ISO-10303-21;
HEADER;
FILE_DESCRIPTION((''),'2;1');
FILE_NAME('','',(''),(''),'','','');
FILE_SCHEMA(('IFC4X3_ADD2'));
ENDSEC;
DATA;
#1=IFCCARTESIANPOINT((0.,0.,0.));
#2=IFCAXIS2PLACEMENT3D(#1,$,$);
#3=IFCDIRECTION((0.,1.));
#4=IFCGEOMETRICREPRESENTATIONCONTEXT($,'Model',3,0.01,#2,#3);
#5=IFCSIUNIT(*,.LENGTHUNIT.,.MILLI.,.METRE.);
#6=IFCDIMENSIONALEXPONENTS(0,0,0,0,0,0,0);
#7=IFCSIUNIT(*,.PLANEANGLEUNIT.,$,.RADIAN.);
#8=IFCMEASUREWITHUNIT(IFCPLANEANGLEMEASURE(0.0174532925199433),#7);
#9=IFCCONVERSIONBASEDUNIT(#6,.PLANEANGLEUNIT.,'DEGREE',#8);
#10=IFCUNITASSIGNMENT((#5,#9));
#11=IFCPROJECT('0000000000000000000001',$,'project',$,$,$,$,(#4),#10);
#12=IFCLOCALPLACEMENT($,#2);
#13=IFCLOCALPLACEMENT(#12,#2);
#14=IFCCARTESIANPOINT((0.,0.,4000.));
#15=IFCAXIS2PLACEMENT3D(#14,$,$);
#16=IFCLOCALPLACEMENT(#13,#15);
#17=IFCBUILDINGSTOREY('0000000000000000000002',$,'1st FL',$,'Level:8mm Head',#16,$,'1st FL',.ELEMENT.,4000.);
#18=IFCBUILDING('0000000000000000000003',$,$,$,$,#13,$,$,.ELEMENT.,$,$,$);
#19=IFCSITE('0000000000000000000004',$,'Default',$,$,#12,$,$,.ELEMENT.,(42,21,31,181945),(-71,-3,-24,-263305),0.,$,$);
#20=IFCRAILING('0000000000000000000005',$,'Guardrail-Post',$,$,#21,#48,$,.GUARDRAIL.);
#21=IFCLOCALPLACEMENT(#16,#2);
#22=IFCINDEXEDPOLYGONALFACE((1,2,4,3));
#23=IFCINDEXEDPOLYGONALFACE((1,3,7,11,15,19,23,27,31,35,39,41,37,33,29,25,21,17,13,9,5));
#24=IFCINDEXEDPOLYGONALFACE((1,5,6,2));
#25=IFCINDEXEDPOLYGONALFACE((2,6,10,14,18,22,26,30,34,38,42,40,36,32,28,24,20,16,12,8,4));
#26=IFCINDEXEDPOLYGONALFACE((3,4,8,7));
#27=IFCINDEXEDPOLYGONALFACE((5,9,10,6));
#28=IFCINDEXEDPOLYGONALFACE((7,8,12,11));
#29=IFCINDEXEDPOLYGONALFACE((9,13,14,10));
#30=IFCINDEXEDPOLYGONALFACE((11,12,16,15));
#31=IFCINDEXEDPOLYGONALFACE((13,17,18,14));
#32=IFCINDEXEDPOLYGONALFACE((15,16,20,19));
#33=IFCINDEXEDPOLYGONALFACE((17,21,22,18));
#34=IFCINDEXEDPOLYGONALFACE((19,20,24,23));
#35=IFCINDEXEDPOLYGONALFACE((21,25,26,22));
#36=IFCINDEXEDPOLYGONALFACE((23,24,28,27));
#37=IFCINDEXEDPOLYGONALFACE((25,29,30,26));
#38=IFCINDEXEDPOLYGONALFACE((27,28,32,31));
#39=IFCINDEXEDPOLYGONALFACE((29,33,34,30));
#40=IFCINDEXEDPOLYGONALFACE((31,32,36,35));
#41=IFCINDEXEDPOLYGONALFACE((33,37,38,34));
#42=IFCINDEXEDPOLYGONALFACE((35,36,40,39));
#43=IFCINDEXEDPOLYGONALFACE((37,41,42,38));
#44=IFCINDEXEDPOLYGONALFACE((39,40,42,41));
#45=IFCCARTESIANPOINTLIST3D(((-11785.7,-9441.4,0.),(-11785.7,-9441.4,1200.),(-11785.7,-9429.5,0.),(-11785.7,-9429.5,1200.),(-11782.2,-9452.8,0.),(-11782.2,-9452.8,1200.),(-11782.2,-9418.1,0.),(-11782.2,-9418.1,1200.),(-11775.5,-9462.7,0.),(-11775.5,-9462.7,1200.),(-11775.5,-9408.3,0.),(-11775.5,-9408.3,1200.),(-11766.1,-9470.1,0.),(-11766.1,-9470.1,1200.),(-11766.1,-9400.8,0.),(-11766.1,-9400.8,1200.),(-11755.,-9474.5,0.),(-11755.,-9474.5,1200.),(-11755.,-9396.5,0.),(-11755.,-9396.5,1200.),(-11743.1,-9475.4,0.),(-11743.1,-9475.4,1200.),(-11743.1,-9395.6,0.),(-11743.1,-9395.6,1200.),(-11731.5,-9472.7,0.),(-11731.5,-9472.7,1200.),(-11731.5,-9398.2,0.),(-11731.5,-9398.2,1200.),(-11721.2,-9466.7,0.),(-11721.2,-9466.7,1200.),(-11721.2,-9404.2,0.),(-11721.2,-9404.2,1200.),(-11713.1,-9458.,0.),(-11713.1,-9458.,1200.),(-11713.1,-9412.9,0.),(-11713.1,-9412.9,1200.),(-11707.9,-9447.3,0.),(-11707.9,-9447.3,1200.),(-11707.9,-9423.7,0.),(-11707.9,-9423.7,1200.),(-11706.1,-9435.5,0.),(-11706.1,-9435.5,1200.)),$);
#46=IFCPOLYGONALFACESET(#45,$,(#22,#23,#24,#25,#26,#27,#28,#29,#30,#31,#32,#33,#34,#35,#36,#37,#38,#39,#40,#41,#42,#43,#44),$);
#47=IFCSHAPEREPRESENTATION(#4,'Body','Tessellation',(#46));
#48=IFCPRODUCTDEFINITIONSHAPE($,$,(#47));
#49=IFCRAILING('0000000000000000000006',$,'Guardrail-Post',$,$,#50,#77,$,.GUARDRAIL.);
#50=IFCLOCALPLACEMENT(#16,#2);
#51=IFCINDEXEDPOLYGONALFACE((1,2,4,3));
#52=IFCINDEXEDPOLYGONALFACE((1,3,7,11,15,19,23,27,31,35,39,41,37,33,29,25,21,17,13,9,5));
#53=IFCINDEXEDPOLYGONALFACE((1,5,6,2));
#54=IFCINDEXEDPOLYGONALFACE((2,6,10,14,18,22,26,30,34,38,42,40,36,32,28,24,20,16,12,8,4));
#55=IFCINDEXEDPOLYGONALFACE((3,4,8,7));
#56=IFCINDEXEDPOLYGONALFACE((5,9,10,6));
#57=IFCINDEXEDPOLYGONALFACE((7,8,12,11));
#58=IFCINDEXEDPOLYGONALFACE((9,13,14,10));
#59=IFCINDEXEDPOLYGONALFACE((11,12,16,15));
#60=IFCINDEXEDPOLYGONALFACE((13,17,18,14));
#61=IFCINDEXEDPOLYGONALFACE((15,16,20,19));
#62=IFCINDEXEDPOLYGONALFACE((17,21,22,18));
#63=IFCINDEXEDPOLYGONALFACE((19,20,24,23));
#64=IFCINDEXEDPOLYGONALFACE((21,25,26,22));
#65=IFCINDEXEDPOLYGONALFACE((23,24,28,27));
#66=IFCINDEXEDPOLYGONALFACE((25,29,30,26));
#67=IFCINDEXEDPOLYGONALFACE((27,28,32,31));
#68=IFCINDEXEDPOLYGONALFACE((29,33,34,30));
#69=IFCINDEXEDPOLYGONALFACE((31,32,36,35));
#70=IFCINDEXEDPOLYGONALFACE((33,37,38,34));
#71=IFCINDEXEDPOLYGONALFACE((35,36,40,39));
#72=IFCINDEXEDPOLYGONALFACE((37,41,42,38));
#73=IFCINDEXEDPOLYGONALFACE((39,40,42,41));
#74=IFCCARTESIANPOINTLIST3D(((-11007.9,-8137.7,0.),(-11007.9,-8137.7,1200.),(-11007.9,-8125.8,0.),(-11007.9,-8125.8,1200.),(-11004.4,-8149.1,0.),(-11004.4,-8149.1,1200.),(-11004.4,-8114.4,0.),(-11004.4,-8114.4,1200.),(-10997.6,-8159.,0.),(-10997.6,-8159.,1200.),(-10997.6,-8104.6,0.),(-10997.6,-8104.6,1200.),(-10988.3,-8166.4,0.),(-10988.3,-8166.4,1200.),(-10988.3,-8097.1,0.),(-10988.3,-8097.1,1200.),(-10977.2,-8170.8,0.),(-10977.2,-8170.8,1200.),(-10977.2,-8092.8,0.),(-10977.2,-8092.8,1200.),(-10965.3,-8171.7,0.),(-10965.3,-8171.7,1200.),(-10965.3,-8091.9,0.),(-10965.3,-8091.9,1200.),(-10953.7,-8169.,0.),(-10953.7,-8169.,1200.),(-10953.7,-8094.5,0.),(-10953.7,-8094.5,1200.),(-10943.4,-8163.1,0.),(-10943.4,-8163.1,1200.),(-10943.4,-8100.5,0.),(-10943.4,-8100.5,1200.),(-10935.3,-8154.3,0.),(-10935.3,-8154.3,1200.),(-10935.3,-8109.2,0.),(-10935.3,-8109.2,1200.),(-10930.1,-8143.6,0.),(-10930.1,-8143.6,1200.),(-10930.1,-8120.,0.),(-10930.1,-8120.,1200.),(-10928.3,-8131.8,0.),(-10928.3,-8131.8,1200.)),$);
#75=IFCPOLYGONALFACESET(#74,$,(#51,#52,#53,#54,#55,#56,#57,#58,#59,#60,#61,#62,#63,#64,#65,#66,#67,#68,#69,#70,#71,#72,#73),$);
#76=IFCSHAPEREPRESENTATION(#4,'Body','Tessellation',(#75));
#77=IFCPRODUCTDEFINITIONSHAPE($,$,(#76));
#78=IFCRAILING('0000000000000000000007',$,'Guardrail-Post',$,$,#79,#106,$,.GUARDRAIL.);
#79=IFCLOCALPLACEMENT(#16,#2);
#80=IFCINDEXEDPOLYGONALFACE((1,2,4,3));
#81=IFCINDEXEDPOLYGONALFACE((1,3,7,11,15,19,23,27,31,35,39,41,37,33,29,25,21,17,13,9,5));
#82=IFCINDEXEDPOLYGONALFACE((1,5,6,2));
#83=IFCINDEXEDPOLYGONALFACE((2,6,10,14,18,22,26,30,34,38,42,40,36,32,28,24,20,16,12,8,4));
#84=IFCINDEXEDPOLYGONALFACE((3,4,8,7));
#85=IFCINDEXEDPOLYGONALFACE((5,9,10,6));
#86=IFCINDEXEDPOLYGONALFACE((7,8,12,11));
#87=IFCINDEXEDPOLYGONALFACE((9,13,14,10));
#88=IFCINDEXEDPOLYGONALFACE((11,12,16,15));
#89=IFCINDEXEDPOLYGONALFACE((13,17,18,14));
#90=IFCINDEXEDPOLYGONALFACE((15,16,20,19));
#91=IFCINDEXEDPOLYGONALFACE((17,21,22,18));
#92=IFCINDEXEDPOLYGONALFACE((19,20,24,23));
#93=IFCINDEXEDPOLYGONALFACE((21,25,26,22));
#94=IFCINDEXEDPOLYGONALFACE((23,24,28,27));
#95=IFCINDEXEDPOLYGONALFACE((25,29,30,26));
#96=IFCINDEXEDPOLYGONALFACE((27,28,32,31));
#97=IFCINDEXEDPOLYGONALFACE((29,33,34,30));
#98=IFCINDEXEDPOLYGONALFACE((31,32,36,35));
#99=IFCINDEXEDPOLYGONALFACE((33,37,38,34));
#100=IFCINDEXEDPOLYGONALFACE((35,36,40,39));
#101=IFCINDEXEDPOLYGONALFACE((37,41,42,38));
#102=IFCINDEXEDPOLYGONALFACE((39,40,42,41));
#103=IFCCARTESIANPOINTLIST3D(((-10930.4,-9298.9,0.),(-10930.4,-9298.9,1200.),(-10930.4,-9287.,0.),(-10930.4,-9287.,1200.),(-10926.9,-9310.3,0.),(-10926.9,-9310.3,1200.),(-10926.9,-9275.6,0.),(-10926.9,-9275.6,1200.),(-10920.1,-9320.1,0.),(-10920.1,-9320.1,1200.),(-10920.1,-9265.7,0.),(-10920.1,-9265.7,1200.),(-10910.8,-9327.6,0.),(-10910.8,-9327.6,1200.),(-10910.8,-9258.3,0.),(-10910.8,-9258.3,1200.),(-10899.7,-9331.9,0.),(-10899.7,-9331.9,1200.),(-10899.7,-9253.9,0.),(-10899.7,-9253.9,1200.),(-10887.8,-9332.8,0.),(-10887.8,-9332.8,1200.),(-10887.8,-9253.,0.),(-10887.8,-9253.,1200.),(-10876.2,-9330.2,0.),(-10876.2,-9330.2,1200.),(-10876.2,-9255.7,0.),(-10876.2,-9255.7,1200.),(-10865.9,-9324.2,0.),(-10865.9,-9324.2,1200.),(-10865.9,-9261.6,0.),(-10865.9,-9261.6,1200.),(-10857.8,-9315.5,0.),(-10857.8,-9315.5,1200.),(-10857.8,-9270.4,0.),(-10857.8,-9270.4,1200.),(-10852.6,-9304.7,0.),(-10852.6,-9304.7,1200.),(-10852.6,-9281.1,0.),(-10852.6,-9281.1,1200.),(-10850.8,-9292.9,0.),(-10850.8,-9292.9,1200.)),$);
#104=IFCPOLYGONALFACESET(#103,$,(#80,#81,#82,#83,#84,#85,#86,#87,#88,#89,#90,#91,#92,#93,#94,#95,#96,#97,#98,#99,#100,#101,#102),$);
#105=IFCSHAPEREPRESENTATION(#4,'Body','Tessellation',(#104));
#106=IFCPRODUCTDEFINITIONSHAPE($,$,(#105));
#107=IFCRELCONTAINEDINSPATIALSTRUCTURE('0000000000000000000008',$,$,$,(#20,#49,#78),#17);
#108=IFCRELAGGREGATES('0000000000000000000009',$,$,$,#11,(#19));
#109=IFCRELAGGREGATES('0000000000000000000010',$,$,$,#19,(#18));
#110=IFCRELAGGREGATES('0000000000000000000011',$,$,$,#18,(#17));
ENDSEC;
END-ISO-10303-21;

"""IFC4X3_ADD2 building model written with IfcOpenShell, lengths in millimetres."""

from ifc_helpers import new_model, entity, si_unit, converted_unit, direction, frame, origin, origin_with_axes, origin_2d, place, context, project, spatial, circle, extrude, element, save


model = new_model("IFC4X3_ADD2")

# Units and contexts
model_context = context("Model", 3, precision=0.01, world=origin(), true_north=direction((0.0, 1.0)))
ifc_project = project(units=[si_unit("LENGTHUNIT", "METRE", prefix="MILLI"), converted_unit("PLANEANGLEUNIT", "DEGREE", entity("IfcPlaneAngleMeasure", 0.0174532925199433), si_unit("PLANEANGLEUNIT", "RADIAN"), dimensions=[0, 0, 0, 0, 0, 0, 0])], contexts=[model_context])

# Site, building, storey
site_placement = place(None, origin())
site = spatial("IfcSite", under=ifc_project, at=site_placement, Name="Default", CompositionType="ELEMENT", RefLatitude=(42, 21, 31, 181945), RefLongitude=(-71, -3, -24, -263305), RefElevation=0.0)
building_placement = place(site_placement, origin())
building = spatial("IfcBuilding", under=site, at=building_placement, CompositionType="ELEMENT")
storey_placement = place(building_placement, frame((0.0, 0.0, 4000.0)))
storey = spatial("IfcBuildingStorey", under=building, at=storey_placement, Name="1st FL", ObjectType="Level:8mm Head", LongName="1st FL", CompositionType="ELEMENT", Elevation=4000.0)

# Railings
for number, where, z_axis, x_axis, name in (
    (1, (-11746.1, -9435.5, 4000.0), (0.0, 0.0, 1.0), (1.0, 0.0, 0.0), "Guardrail-Post"),
    (2, (-10968.3, -8131.8, 4000.0), (0.0, 0.0, 1.0), (1.0, 0.0, 0.0), "Guardrail-Post"),
    (3, (-10890.8, -9292.9, 4000.0), (0.0, 0.0, 1.0), (1.0, 0.0, 0.0), "Guardrail-Post"),
):
    element("IfcRailing", number, at=place(None, frame(where, z_axis=z_axis, x_axis=x_axis)), inside=storey, Name=name, PredefinedType="GUARDRAIL", context=model_context, shape_type="SweptSolid", body=[
        extrude(circle(Radius=40.0, at=origin_2d()), origin_with_axes(), (0.0, 0.0, 1.0), 1200.0),
    ])

save(model, "model.ifc")
